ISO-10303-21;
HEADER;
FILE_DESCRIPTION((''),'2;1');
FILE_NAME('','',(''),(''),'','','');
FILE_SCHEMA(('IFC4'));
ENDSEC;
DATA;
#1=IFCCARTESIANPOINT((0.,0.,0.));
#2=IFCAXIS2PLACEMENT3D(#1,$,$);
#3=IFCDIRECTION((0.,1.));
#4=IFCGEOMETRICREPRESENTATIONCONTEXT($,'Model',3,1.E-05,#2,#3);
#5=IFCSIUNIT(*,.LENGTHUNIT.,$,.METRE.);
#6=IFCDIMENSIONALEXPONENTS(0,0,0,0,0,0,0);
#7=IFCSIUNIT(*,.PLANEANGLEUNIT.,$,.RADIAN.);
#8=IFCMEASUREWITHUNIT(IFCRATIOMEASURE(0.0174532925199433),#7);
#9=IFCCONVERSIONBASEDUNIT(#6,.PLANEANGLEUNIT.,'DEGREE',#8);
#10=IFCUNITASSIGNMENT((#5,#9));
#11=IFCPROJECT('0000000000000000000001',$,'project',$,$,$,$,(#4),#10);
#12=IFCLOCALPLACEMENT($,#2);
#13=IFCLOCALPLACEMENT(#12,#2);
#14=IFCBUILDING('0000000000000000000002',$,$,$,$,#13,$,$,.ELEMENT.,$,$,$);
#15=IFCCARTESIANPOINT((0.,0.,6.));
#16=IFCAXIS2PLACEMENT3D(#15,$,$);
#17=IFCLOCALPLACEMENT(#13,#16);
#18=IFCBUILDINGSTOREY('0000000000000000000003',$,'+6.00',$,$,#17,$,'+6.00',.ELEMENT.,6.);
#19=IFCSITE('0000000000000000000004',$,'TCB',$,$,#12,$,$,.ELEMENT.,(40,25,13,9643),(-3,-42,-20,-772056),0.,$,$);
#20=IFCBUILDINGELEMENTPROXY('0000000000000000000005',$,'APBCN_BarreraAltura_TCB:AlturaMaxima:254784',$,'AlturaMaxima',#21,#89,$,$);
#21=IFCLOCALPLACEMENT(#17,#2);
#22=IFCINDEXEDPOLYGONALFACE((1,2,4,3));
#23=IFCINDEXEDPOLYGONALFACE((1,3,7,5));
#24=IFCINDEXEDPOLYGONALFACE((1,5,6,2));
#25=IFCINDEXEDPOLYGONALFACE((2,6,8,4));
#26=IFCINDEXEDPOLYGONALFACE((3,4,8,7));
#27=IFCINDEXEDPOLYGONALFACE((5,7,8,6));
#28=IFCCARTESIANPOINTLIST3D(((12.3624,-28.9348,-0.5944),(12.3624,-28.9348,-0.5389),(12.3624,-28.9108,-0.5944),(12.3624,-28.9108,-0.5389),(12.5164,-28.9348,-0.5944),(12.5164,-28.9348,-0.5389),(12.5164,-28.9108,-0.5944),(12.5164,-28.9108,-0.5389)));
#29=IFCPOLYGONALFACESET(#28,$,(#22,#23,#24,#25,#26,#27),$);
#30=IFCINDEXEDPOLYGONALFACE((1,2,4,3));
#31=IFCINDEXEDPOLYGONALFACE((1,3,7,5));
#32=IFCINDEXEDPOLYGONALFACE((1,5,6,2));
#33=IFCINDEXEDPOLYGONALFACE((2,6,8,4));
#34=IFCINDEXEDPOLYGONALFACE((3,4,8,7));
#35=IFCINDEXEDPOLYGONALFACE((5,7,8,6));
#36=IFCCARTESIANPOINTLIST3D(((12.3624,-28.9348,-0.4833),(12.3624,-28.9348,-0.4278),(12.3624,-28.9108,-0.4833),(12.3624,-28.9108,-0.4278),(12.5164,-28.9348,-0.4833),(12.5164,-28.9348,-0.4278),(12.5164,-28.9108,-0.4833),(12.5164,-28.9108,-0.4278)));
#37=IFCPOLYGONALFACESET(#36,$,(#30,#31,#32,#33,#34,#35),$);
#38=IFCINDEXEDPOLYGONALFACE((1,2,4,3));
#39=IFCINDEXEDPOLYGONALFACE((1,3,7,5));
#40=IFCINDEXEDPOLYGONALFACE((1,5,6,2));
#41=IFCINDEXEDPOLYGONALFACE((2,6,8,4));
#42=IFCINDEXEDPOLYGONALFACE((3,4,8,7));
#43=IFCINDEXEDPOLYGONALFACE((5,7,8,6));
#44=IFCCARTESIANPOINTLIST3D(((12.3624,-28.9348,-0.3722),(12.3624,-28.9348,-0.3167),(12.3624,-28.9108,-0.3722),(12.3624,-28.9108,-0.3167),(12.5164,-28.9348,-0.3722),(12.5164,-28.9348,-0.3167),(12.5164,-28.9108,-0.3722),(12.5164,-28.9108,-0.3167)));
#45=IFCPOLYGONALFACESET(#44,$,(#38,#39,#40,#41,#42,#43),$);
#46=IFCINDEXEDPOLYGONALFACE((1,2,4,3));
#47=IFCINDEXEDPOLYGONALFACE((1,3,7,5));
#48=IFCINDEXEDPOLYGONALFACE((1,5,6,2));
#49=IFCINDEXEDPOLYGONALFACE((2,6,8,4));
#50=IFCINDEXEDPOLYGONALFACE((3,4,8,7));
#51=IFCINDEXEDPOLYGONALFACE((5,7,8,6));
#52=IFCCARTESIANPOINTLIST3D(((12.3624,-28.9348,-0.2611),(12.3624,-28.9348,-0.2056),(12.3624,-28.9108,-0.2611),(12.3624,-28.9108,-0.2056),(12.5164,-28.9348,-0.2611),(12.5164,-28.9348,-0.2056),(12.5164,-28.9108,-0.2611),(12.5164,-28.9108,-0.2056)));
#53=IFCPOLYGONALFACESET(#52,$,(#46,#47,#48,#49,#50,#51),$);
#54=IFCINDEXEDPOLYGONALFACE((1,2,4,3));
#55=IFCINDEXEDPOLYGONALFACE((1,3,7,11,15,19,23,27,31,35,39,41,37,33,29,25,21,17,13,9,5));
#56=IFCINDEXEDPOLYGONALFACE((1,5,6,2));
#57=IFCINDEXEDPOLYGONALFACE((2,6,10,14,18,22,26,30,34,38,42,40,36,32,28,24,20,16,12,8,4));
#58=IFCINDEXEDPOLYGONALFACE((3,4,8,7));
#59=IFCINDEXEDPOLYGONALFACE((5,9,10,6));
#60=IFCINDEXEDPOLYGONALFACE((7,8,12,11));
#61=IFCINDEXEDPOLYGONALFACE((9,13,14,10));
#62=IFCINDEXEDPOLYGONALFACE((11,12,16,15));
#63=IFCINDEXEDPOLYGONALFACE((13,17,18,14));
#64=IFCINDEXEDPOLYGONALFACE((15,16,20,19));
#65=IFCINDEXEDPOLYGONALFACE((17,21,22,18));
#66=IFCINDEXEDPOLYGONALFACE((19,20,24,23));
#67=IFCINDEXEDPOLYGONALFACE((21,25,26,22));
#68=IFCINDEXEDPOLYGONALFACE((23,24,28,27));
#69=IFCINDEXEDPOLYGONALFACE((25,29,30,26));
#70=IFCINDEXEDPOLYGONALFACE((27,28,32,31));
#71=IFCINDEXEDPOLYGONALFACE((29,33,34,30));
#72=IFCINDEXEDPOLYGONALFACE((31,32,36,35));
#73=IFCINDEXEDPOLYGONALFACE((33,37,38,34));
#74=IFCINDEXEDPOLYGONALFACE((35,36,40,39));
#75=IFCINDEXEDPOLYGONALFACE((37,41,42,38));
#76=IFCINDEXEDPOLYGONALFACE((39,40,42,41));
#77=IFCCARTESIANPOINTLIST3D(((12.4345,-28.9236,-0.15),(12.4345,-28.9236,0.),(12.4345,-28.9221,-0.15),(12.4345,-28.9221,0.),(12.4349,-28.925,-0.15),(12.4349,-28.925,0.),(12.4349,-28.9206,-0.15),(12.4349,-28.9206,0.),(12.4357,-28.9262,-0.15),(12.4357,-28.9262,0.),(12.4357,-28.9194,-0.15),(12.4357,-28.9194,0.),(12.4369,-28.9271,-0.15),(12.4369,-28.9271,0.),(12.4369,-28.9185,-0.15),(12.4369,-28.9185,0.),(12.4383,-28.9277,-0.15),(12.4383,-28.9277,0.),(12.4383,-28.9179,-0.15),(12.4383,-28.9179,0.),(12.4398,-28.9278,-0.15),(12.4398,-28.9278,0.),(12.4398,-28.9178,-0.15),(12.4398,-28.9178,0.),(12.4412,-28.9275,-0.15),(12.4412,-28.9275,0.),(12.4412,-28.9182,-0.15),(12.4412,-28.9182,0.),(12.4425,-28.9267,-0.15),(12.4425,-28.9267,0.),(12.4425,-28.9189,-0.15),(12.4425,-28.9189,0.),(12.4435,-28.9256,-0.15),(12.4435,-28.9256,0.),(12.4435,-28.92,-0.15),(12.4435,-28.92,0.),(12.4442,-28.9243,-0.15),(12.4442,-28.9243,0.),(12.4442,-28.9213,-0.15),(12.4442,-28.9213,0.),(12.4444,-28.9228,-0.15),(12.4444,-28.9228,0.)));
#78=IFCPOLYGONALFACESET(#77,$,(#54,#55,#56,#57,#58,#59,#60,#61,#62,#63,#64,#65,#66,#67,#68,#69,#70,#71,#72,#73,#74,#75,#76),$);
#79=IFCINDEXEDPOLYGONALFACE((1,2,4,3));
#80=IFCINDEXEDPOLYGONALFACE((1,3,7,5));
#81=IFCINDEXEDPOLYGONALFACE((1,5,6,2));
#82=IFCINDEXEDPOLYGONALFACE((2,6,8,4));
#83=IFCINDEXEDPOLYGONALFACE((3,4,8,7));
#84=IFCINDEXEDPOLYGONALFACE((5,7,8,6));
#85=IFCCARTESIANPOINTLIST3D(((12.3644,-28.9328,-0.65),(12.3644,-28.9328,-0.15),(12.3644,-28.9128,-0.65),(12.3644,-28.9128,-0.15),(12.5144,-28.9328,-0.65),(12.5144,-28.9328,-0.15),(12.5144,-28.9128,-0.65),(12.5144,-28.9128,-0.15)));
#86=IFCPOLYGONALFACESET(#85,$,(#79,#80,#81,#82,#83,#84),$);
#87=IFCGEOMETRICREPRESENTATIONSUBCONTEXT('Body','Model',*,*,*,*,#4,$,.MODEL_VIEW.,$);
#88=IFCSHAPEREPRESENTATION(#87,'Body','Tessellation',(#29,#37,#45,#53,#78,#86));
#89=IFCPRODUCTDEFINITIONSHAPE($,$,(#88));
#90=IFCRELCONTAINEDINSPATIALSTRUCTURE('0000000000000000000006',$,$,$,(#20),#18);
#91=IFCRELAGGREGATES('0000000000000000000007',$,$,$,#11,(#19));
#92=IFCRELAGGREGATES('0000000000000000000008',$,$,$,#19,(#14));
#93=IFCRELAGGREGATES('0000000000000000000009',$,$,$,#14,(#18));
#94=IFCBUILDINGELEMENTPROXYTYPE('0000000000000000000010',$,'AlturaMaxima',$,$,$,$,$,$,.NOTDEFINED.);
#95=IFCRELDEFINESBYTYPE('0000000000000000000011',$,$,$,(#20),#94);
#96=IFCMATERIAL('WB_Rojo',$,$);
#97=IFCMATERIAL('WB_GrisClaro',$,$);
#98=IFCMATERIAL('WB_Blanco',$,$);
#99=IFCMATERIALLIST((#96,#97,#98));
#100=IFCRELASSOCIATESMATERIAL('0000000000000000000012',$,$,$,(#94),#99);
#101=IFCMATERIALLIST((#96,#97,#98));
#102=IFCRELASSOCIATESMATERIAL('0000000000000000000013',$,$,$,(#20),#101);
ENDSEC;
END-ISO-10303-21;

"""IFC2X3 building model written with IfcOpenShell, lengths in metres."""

from ifc_helpers import new_model, entity, si_unit, converted_unit, direction, frame, frame_2d, origin, origin_2d_with_axis, place, context, subcontext, project, spatial, rectangle, circle, extrude, source, transform, mapped, material, material_list, type_object, type_shapes, element, save


model = new_model("IFC2X3")

# Units and contexts
model_context = context("Model", 3, precision=1e-05, world=origin(), true_north=direction((0.0, 1.0)))
body_context = subcontext(model_context, "Body", "Model", "MODEL_VIEW")
ifc_project = project(units=[si_unit("LENGTHUNIT", "METRE"), converted_unit("PLANEANGLEUNIT", "DEGREE", entity("IfcRatioMeasure", 0.0174532925199433), si_unit("PLANEANGLEUNIT", "RADIAN"), dimensions=[0, 0, 0, 0, 0, 0, 0])], contexts=[model_context])

# Site, building, storey
site_placement = place(None, origin())
site = spatial("IfcSite", under=ifc_project, at=site_placement, Name="TCB", CompositionType="ELEMENT", RefLatitude=(40, 25, 13, 9643), RefLongitude=(-3, -42, -20, -772056), RefElevation=0.0)
building_placement = place(site_placement, origin())
building = spatial("IfcBuilding", under=site, at=building_placement, CompositionType="ELEMENT")
storey_placement = place(building_placement, frame((0.0, 0.0, 6.0)))
storey = spatial("IfcBuildingStorey", under=building, at=storey_placement, Name="+6.00", LongName="+6.00", CompositionType="ELEMENT", Elevation=6.0)

# Building element proxy
ifc_material_1 = material(Name="WB_Rojo")
ifc_material_2 = material(Name="WB_GrisClaro")
ifc_material_3 = material(Name="WB_Blanco")
ifc_material_list_1 = material_list([ifc_material_1, ifc_material_2, ifc_material_3])
building_element_proxy_type = type_object("IfcBuildingElementProxyType", Name="AlturaMaxima", PredefinedType="NOTDEFINED", material=ifc_material_list_1)
shared_shape = source(origin(), body_context, "Body", "SweptSolid", [
    extrude(rectangle(XDim=0.154, YDim=0.024, at=frame_2d((0.0, 0.0), x_axis=(1.0, 0.0))), frame((0.0, 0.0, -0.5944), z_axis=(0.0, 0.0, 1.0), x_axis=(-1.0, 0.0, 0.0)), (0.0, 0.0, 1.0), 0.0556),
    extrude(rectangle(XDim=0.154, YDim=0.024, at=frame_2d((0.0, 0.0), x_axis=(1.0, 0.0))), frame((0.0, 0.0, -0.4833), z_axis=(0.0, 0.0, 1.0), x_axis=(-1.0, 0.0, 0.0)), (0.0, 0.0, 1.0), 0.0556),
    extrude(rectangle(XDim=0.154, YDim=0.024, at=frame_2d((0.0, 0.0), x_axis=(1.0, 0.0))), frame((0.0, 0.0, -0.3722), z_axis=(0.0, 0.0, 1.0), x_axis=(-1.0, 0.0, 0.0)), (0.0, 0.0, 1.0), 0.0556),
    extrude(rectangle(XDim=0.154, YDim=0.024, at=frame_2d((0.0, 0.0), x_axis=(1.0, 0.0))), frame((0.0, 0.0, -0.2611), z_axis=(0.0, 0.0, 1.0), x_axis=(-1.0, 0.0, 0.0)), (0.0, 0.0, 1.0), 0.0556),
    extrude(circle(Radius=0.005, at=frame_2d((0.0, 0.0), x_axis=(1.0, 0.0))), frame((0.0, 0.0, -0.15)), (0.0, 0.0, 1.0), 0.15),
    extrude(rectangle(XDim=0.02, YDim=0.15, at=origin_2d_with_axis()), frame((0.0, 0.0, -0.65), z_axis=(0.0, 0.0, 1.0), x_axis=(0.0, 1.0, 0.0)), (0.0, 0.0, 1.0), 0.5),
])
type_shapes(building_element_proxy_type, [shared_shape])
ifc_material_list_2 = material_list([ifc_material_1, ifc_material_2, ifc_material_3])
proxy_1_placement = place(storey_placement, frame((12.4394, -28.9228, 0.0)))
element("IfcBuildingElementProxy", 1, at=proxy_1_placement, inside=storey, type_object=building_element_proxy_type, material=ifc_material_list_2, Name="APBCN_BarreraAltura_TCB:AlturaMaxima:254784", ObjectType="AlturaMaxima", context=body_context, shape_type="MappedRepresentation", body=[
    mapped(shared_shape, transform((0.0, 0.0, 0.0), scale=1.0)),
])

save(model, "model.ifc")
